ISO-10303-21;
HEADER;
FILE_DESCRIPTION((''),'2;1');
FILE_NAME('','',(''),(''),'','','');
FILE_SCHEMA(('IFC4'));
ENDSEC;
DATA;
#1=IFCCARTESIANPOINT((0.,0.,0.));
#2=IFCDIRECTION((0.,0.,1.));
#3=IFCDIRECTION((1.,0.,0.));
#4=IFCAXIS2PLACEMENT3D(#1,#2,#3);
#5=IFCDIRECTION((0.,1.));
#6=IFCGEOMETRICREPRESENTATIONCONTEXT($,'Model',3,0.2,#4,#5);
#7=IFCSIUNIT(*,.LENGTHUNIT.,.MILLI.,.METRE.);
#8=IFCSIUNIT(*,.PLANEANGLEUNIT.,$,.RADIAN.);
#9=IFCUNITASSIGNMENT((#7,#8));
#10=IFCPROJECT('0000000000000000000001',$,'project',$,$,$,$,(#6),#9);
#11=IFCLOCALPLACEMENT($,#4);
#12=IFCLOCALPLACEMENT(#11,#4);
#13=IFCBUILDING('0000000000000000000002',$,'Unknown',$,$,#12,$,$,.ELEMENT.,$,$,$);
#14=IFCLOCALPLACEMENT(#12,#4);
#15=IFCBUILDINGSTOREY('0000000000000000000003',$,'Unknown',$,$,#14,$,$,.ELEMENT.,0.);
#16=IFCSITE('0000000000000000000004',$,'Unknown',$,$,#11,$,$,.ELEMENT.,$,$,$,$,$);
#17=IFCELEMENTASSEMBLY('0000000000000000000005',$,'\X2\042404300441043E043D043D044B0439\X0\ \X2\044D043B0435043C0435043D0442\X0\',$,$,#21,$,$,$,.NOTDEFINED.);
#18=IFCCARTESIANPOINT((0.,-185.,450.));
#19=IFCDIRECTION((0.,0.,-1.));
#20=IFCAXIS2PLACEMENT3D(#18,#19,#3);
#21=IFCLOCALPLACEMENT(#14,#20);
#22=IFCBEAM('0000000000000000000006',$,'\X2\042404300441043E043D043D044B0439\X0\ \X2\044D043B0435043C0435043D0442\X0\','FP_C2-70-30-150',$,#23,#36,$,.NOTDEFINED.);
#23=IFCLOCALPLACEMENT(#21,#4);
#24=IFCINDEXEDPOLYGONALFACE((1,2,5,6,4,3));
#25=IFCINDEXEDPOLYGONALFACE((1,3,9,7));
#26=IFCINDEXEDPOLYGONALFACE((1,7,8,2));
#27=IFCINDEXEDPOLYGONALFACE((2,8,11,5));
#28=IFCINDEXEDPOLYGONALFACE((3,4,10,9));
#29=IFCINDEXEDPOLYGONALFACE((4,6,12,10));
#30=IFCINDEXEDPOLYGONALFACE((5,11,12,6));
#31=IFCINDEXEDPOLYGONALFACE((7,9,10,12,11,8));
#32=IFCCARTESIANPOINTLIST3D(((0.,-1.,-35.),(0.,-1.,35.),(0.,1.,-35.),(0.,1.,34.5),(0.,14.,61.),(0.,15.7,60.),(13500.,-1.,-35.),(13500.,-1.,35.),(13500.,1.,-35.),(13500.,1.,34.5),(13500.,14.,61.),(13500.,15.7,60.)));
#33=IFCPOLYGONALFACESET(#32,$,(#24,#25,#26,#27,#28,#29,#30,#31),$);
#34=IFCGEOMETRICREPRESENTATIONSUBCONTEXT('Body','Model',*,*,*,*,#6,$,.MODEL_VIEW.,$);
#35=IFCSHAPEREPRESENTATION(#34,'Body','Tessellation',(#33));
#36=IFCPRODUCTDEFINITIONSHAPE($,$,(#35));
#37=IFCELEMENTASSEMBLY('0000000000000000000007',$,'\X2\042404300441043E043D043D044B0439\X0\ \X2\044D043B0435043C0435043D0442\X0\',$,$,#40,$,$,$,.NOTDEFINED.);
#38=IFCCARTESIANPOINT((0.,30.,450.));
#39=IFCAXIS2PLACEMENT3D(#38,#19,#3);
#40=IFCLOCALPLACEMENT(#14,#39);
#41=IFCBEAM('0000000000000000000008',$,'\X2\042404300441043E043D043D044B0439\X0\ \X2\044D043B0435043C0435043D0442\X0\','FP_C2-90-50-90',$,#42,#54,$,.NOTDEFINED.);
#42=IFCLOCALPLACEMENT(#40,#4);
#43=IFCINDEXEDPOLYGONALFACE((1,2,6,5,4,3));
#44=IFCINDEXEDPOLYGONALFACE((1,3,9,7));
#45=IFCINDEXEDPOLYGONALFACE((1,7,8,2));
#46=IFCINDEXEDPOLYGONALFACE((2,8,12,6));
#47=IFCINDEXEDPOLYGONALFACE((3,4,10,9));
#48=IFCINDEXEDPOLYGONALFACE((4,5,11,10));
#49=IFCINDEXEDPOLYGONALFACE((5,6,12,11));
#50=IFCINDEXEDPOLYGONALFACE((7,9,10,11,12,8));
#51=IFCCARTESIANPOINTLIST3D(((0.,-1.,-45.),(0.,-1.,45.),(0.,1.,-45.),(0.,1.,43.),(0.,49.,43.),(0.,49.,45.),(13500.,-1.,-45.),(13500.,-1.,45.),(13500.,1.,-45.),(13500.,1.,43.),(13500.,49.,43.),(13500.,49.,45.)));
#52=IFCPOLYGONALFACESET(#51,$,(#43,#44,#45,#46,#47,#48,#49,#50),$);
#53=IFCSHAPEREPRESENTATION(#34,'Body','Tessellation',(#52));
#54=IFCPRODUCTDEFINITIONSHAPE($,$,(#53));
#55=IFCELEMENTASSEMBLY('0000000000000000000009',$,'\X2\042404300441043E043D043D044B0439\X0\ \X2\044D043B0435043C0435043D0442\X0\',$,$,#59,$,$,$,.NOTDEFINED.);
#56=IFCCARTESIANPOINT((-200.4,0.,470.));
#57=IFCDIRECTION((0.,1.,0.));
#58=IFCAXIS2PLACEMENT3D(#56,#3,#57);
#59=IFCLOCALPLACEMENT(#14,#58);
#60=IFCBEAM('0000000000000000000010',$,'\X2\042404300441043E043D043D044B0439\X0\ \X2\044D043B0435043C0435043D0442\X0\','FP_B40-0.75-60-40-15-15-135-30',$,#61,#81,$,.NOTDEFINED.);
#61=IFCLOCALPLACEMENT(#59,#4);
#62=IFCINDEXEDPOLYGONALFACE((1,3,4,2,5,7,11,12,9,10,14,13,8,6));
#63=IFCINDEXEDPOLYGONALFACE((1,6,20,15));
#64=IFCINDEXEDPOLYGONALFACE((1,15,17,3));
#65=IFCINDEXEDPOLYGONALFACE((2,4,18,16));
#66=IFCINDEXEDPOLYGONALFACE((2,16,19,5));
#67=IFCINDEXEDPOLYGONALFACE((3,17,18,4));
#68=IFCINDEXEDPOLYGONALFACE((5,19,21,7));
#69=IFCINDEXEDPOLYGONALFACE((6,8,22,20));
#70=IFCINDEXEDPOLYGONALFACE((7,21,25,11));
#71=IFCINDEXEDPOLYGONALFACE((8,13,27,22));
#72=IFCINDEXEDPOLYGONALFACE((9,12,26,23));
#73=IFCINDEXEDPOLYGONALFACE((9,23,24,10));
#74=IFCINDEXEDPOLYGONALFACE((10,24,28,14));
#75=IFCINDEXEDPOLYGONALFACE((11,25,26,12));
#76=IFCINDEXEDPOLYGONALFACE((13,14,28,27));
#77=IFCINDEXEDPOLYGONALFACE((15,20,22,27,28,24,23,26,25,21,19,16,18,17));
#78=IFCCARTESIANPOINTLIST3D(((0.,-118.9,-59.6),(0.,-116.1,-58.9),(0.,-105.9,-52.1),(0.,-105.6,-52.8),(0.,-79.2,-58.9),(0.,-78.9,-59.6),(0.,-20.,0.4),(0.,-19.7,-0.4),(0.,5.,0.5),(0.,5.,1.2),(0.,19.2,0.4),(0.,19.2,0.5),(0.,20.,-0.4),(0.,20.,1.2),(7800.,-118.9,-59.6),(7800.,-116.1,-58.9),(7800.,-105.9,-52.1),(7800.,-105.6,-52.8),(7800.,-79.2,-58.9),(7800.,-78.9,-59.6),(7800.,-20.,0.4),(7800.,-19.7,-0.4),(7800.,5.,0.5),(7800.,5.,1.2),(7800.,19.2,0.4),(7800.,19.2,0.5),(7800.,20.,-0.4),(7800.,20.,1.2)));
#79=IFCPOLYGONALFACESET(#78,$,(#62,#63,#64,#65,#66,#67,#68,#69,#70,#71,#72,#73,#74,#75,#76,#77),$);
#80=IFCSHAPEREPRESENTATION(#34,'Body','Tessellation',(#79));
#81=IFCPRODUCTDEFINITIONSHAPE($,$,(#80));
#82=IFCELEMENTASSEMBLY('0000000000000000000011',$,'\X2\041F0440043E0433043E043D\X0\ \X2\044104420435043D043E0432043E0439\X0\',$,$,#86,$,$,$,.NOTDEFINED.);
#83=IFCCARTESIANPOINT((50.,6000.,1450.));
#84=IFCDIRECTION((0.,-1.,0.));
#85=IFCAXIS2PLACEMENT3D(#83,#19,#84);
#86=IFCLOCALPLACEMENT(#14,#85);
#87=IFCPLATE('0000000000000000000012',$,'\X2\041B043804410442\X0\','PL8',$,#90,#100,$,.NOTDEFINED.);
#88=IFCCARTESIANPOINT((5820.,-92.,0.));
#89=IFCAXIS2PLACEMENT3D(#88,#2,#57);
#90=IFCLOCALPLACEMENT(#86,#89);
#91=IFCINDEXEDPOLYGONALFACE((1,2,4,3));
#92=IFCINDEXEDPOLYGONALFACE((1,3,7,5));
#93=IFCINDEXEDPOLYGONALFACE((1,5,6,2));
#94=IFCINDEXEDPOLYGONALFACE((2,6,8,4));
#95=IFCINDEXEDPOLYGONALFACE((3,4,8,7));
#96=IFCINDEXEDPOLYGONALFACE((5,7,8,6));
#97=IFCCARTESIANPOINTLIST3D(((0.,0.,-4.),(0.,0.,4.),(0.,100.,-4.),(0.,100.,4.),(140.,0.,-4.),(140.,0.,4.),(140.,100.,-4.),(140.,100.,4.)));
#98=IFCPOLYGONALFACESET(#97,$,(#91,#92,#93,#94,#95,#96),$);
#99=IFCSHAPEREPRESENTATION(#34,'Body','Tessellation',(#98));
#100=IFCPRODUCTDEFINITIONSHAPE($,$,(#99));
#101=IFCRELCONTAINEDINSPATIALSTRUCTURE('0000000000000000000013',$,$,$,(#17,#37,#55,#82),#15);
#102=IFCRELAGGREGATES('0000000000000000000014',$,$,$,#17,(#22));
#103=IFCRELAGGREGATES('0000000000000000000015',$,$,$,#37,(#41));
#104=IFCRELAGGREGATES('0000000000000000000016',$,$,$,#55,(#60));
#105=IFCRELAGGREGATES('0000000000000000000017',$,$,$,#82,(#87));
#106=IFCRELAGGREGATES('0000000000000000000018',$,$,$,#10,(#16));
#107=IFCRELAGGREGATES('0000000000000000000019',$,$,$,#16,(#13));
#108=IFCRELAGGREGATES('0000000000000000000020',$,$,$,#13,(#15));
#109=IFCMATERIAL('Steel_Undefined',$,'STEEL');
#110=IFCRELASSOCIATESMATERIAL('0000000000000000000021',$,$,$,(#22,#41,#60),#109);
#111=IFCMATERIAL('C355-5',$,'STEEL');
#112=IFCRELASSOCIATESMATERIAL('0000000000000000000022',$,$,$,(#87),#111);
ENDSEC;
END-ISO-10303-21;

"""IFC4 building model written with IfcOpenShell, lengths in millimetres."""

from ifc_helpers import new_model, si_unit, direction, frame, origin_with_axes, place, context, subcontext, project, spatial, line, indexed_curve, outline, extrude, material, element, aggregate, save


model = new_model("IFC4")

# Units and contexts
model_context = context("Model", 3, precision=0.2, world=origin_with_axes(), true_north=direction((0.0, 1.0)))
body_context = subcontext(model_context, "Body", "Model", "MODEL_VIEW")
ifc_project = project(units=[si_unit("LENGTHUNIT", "METRE", prefix="MILLI"), si_unit("PLANEANGLEUNIT", "RADIAN")], contexts=[model_context])

# Site, building, storey
site_placement = place(None, origin_with_axes())
site = spatial("IfcSite", under=ifc_project, at=site_placement, Name="Unknown", CompositionType="ELEMENT")
building_placement = place(site_placement, origin_with_axes())
building = spatial("IfcBuilding", under=site, at=building_placement, Name="Unknown", CompositionType="ELEMENT")
storey_placement = place(building_placement, origin_with_axes())
storey = spatial("IfcBuildingStorey", under=building, at=storey_placement, Name="Unknown", CompositionType="ELEMENT", Elevation=0.0)

# Shared definitions
ifc_material_1 = material(Name="Steel_Undefined", Category="STEEL")

# Shared definitions
ifc_material_2 = material(Name="C355-5", Category="STEEL")

# Element assemblies, beams
assembly_1_placement = place(storey_placement, frame((0.0, -185.0, 450.0), z_axis=(0.0, 0.0, -1.0), x_axis=(1.0, 0.0, 0.0)))
assembly_1 = element("IfcElementAssembly", 1, at=assembly_1_placement, inside=storey, Name="Фасонный элемент", PredefinedType="NOTDEFINED")
beam_1_placement = place(assembly_1_placement, origin_with_axes())
beam_1 = element("IfcBeam", 2, at=beam_1_placement, material=ifc_material_1, Name="Фасонный элемент", Description="FP_C2-70-30-150", PredefinedType="NOTDEFINED", context=body_context, shape_type="SolidModel", body=[
    extrude(outline(indexed_curve([(-35.0, -1.0), (35.0, -1.0), (61.0, 14.0), (60.0, 15.7), (34.5, 1.0), (-35.0, 1.0)], segments=[line(1, 2, 3, 4, 5, 6, 1)])), frame((0.0, 0.0, 0.0), z_axis=(-1.0, 0.0, 0.0), x_axis=(0.0, 0.0, 1.0)), (0.0, 0.0, -1.0), 13500.0),
])
aggregate(assembly_1, [beam_1])
assembly_2_placement = place(storey_placement, frame((0.0, 30.0, 450.0), z_axis=(0.0, 0.0, -1.0), x_axis=(1.0, 0.0, 0.0)))
assembly_2 = element("IfcElementAssembly", 3, at=assembly_2_placement, inside=storey, Name="Фасонный элемент", PredefinedType="NOTDEFINED")
beam_2_placement = place(assembly_2_placement, origin_with_axes())
beam_2 = element("IfcBeam", 4, at=beam_2_placement, material=ifc_material_1, Name="Фасонный элемент", Description="FP_C2-90-50-90", PredefinedType="NOTDEFINED", context=body_context, shape_type="SolidModel", body=[
    extrude(outline(indexed_curve([(-45.0, -1.0), (45.0, -1.0), (45.0, 49.0), (43.0, 49.0), (43.0, 1.0), (-45.0, 1.0)], segments=[line(1, 2, 3, 4, 5, 6, 1)])), frame((0.0, 0.0, 0.0), z_axis=(-1.0, 0.0, 0.0), x_axis=(0.0, 0.0, 1.0)), (0.0, 0.0, -1.0), 13500.0),
])
aggregate(assembly_2, [beam_2])
assembly_3_placement = place(storey_placement, frame((-200.4, 0.0, 470.0), z_axis=(1.0, 0.0, 0.0), x_axis=(0.0, 1.0, 0.0)))
assembly_3 = element("IfcElementAssembly", 5, at=assembly_3_placement, inside=storey, Name="Фасонный элемент", PredefinedType="NOTDEFINED")
beam_3_placement = place(assembly_3_placement, origin_with_axes())
beam_3 = element("IfcBeam", 6, at=beam_3_placement, material=ifc_material_1, Name="Фасонный элемент", Description="FP_B40-0.75-60-40-15-15-135-30", PredefinedType="NOTDEFINED", context=body_context, shape_type="SolidModel", body=[
    extrude(outline(indexed_curve([(0.4, -20.0), (0.4, 19.2), (0.5, 19.2), (0.5, 5.0), (1.2, 5.0), (1.2, 20.0), (-0.4, 20.0), (-0.4, -19.7), (-59.6, -78.9), (-59.6, -118.9), (-52.1, -105.9), (-52.8, -105.6), (-58.9, -116.1), (-58.9, -79.2)], segments=[line(1, 2, 3, 4, 5, 6, 7, 8, 9, 10, 11, 12, 13, 14, 1)])), frame((0.0, 0.0, 0.0), z_axis=(-1.0, 0.0, 0.0), x_axis=(0.0, 0.0, 1.0)), (0.0, 0.0, -1.0), 7800.0),
])
aggregate(assembly_3, [beam_3])

# Element assembly, plate
assembly_4_placement = place(storey_placement, frame((50.0, 6000.0, 1450.0), z_axis=(0.0, 0.0, -1.0), x_axis=(0.0, -1.0, 0.0)))
assembly_4 = element("IfcElementAssembly", 7, at=assembly_4_placement, inside=storey, Name="Прогон стеновой", PredefinedType="NOTDEFINED")
plate_1_placement = place(assembly_4_placement, frame((5820.0, -92.0, 0.0), z_axis=(0.0, 0.0, 1.0), x_axis=(0.0, 1.0, 0.0)))
plate_1 = element("IfcPlate", 8, at=plate_1_placement, material=ifc_material_2, Name="Лист", Description="PL8", PredefinedType="NOTDEFINED", context=body_context, shape_type="SolidModel", body=[
    extrude(outline(indexed_curve([(0.0, 0.0), (140.0, 0.0), (140.0, 100.0), (0.0, 100.0)], segments=[line(1, 2, 3, 4, 1)])), frame((0.0, 0.0, 4.0), z_axis=(0.0, 0.0, 1.0), x_axis=(1.0, 0.0, 0.0)), (0.0, 0.0, -1.0), 8.0),
])
aggregate(assembly_4, [plate_1])

save(model, "model.ifc")
